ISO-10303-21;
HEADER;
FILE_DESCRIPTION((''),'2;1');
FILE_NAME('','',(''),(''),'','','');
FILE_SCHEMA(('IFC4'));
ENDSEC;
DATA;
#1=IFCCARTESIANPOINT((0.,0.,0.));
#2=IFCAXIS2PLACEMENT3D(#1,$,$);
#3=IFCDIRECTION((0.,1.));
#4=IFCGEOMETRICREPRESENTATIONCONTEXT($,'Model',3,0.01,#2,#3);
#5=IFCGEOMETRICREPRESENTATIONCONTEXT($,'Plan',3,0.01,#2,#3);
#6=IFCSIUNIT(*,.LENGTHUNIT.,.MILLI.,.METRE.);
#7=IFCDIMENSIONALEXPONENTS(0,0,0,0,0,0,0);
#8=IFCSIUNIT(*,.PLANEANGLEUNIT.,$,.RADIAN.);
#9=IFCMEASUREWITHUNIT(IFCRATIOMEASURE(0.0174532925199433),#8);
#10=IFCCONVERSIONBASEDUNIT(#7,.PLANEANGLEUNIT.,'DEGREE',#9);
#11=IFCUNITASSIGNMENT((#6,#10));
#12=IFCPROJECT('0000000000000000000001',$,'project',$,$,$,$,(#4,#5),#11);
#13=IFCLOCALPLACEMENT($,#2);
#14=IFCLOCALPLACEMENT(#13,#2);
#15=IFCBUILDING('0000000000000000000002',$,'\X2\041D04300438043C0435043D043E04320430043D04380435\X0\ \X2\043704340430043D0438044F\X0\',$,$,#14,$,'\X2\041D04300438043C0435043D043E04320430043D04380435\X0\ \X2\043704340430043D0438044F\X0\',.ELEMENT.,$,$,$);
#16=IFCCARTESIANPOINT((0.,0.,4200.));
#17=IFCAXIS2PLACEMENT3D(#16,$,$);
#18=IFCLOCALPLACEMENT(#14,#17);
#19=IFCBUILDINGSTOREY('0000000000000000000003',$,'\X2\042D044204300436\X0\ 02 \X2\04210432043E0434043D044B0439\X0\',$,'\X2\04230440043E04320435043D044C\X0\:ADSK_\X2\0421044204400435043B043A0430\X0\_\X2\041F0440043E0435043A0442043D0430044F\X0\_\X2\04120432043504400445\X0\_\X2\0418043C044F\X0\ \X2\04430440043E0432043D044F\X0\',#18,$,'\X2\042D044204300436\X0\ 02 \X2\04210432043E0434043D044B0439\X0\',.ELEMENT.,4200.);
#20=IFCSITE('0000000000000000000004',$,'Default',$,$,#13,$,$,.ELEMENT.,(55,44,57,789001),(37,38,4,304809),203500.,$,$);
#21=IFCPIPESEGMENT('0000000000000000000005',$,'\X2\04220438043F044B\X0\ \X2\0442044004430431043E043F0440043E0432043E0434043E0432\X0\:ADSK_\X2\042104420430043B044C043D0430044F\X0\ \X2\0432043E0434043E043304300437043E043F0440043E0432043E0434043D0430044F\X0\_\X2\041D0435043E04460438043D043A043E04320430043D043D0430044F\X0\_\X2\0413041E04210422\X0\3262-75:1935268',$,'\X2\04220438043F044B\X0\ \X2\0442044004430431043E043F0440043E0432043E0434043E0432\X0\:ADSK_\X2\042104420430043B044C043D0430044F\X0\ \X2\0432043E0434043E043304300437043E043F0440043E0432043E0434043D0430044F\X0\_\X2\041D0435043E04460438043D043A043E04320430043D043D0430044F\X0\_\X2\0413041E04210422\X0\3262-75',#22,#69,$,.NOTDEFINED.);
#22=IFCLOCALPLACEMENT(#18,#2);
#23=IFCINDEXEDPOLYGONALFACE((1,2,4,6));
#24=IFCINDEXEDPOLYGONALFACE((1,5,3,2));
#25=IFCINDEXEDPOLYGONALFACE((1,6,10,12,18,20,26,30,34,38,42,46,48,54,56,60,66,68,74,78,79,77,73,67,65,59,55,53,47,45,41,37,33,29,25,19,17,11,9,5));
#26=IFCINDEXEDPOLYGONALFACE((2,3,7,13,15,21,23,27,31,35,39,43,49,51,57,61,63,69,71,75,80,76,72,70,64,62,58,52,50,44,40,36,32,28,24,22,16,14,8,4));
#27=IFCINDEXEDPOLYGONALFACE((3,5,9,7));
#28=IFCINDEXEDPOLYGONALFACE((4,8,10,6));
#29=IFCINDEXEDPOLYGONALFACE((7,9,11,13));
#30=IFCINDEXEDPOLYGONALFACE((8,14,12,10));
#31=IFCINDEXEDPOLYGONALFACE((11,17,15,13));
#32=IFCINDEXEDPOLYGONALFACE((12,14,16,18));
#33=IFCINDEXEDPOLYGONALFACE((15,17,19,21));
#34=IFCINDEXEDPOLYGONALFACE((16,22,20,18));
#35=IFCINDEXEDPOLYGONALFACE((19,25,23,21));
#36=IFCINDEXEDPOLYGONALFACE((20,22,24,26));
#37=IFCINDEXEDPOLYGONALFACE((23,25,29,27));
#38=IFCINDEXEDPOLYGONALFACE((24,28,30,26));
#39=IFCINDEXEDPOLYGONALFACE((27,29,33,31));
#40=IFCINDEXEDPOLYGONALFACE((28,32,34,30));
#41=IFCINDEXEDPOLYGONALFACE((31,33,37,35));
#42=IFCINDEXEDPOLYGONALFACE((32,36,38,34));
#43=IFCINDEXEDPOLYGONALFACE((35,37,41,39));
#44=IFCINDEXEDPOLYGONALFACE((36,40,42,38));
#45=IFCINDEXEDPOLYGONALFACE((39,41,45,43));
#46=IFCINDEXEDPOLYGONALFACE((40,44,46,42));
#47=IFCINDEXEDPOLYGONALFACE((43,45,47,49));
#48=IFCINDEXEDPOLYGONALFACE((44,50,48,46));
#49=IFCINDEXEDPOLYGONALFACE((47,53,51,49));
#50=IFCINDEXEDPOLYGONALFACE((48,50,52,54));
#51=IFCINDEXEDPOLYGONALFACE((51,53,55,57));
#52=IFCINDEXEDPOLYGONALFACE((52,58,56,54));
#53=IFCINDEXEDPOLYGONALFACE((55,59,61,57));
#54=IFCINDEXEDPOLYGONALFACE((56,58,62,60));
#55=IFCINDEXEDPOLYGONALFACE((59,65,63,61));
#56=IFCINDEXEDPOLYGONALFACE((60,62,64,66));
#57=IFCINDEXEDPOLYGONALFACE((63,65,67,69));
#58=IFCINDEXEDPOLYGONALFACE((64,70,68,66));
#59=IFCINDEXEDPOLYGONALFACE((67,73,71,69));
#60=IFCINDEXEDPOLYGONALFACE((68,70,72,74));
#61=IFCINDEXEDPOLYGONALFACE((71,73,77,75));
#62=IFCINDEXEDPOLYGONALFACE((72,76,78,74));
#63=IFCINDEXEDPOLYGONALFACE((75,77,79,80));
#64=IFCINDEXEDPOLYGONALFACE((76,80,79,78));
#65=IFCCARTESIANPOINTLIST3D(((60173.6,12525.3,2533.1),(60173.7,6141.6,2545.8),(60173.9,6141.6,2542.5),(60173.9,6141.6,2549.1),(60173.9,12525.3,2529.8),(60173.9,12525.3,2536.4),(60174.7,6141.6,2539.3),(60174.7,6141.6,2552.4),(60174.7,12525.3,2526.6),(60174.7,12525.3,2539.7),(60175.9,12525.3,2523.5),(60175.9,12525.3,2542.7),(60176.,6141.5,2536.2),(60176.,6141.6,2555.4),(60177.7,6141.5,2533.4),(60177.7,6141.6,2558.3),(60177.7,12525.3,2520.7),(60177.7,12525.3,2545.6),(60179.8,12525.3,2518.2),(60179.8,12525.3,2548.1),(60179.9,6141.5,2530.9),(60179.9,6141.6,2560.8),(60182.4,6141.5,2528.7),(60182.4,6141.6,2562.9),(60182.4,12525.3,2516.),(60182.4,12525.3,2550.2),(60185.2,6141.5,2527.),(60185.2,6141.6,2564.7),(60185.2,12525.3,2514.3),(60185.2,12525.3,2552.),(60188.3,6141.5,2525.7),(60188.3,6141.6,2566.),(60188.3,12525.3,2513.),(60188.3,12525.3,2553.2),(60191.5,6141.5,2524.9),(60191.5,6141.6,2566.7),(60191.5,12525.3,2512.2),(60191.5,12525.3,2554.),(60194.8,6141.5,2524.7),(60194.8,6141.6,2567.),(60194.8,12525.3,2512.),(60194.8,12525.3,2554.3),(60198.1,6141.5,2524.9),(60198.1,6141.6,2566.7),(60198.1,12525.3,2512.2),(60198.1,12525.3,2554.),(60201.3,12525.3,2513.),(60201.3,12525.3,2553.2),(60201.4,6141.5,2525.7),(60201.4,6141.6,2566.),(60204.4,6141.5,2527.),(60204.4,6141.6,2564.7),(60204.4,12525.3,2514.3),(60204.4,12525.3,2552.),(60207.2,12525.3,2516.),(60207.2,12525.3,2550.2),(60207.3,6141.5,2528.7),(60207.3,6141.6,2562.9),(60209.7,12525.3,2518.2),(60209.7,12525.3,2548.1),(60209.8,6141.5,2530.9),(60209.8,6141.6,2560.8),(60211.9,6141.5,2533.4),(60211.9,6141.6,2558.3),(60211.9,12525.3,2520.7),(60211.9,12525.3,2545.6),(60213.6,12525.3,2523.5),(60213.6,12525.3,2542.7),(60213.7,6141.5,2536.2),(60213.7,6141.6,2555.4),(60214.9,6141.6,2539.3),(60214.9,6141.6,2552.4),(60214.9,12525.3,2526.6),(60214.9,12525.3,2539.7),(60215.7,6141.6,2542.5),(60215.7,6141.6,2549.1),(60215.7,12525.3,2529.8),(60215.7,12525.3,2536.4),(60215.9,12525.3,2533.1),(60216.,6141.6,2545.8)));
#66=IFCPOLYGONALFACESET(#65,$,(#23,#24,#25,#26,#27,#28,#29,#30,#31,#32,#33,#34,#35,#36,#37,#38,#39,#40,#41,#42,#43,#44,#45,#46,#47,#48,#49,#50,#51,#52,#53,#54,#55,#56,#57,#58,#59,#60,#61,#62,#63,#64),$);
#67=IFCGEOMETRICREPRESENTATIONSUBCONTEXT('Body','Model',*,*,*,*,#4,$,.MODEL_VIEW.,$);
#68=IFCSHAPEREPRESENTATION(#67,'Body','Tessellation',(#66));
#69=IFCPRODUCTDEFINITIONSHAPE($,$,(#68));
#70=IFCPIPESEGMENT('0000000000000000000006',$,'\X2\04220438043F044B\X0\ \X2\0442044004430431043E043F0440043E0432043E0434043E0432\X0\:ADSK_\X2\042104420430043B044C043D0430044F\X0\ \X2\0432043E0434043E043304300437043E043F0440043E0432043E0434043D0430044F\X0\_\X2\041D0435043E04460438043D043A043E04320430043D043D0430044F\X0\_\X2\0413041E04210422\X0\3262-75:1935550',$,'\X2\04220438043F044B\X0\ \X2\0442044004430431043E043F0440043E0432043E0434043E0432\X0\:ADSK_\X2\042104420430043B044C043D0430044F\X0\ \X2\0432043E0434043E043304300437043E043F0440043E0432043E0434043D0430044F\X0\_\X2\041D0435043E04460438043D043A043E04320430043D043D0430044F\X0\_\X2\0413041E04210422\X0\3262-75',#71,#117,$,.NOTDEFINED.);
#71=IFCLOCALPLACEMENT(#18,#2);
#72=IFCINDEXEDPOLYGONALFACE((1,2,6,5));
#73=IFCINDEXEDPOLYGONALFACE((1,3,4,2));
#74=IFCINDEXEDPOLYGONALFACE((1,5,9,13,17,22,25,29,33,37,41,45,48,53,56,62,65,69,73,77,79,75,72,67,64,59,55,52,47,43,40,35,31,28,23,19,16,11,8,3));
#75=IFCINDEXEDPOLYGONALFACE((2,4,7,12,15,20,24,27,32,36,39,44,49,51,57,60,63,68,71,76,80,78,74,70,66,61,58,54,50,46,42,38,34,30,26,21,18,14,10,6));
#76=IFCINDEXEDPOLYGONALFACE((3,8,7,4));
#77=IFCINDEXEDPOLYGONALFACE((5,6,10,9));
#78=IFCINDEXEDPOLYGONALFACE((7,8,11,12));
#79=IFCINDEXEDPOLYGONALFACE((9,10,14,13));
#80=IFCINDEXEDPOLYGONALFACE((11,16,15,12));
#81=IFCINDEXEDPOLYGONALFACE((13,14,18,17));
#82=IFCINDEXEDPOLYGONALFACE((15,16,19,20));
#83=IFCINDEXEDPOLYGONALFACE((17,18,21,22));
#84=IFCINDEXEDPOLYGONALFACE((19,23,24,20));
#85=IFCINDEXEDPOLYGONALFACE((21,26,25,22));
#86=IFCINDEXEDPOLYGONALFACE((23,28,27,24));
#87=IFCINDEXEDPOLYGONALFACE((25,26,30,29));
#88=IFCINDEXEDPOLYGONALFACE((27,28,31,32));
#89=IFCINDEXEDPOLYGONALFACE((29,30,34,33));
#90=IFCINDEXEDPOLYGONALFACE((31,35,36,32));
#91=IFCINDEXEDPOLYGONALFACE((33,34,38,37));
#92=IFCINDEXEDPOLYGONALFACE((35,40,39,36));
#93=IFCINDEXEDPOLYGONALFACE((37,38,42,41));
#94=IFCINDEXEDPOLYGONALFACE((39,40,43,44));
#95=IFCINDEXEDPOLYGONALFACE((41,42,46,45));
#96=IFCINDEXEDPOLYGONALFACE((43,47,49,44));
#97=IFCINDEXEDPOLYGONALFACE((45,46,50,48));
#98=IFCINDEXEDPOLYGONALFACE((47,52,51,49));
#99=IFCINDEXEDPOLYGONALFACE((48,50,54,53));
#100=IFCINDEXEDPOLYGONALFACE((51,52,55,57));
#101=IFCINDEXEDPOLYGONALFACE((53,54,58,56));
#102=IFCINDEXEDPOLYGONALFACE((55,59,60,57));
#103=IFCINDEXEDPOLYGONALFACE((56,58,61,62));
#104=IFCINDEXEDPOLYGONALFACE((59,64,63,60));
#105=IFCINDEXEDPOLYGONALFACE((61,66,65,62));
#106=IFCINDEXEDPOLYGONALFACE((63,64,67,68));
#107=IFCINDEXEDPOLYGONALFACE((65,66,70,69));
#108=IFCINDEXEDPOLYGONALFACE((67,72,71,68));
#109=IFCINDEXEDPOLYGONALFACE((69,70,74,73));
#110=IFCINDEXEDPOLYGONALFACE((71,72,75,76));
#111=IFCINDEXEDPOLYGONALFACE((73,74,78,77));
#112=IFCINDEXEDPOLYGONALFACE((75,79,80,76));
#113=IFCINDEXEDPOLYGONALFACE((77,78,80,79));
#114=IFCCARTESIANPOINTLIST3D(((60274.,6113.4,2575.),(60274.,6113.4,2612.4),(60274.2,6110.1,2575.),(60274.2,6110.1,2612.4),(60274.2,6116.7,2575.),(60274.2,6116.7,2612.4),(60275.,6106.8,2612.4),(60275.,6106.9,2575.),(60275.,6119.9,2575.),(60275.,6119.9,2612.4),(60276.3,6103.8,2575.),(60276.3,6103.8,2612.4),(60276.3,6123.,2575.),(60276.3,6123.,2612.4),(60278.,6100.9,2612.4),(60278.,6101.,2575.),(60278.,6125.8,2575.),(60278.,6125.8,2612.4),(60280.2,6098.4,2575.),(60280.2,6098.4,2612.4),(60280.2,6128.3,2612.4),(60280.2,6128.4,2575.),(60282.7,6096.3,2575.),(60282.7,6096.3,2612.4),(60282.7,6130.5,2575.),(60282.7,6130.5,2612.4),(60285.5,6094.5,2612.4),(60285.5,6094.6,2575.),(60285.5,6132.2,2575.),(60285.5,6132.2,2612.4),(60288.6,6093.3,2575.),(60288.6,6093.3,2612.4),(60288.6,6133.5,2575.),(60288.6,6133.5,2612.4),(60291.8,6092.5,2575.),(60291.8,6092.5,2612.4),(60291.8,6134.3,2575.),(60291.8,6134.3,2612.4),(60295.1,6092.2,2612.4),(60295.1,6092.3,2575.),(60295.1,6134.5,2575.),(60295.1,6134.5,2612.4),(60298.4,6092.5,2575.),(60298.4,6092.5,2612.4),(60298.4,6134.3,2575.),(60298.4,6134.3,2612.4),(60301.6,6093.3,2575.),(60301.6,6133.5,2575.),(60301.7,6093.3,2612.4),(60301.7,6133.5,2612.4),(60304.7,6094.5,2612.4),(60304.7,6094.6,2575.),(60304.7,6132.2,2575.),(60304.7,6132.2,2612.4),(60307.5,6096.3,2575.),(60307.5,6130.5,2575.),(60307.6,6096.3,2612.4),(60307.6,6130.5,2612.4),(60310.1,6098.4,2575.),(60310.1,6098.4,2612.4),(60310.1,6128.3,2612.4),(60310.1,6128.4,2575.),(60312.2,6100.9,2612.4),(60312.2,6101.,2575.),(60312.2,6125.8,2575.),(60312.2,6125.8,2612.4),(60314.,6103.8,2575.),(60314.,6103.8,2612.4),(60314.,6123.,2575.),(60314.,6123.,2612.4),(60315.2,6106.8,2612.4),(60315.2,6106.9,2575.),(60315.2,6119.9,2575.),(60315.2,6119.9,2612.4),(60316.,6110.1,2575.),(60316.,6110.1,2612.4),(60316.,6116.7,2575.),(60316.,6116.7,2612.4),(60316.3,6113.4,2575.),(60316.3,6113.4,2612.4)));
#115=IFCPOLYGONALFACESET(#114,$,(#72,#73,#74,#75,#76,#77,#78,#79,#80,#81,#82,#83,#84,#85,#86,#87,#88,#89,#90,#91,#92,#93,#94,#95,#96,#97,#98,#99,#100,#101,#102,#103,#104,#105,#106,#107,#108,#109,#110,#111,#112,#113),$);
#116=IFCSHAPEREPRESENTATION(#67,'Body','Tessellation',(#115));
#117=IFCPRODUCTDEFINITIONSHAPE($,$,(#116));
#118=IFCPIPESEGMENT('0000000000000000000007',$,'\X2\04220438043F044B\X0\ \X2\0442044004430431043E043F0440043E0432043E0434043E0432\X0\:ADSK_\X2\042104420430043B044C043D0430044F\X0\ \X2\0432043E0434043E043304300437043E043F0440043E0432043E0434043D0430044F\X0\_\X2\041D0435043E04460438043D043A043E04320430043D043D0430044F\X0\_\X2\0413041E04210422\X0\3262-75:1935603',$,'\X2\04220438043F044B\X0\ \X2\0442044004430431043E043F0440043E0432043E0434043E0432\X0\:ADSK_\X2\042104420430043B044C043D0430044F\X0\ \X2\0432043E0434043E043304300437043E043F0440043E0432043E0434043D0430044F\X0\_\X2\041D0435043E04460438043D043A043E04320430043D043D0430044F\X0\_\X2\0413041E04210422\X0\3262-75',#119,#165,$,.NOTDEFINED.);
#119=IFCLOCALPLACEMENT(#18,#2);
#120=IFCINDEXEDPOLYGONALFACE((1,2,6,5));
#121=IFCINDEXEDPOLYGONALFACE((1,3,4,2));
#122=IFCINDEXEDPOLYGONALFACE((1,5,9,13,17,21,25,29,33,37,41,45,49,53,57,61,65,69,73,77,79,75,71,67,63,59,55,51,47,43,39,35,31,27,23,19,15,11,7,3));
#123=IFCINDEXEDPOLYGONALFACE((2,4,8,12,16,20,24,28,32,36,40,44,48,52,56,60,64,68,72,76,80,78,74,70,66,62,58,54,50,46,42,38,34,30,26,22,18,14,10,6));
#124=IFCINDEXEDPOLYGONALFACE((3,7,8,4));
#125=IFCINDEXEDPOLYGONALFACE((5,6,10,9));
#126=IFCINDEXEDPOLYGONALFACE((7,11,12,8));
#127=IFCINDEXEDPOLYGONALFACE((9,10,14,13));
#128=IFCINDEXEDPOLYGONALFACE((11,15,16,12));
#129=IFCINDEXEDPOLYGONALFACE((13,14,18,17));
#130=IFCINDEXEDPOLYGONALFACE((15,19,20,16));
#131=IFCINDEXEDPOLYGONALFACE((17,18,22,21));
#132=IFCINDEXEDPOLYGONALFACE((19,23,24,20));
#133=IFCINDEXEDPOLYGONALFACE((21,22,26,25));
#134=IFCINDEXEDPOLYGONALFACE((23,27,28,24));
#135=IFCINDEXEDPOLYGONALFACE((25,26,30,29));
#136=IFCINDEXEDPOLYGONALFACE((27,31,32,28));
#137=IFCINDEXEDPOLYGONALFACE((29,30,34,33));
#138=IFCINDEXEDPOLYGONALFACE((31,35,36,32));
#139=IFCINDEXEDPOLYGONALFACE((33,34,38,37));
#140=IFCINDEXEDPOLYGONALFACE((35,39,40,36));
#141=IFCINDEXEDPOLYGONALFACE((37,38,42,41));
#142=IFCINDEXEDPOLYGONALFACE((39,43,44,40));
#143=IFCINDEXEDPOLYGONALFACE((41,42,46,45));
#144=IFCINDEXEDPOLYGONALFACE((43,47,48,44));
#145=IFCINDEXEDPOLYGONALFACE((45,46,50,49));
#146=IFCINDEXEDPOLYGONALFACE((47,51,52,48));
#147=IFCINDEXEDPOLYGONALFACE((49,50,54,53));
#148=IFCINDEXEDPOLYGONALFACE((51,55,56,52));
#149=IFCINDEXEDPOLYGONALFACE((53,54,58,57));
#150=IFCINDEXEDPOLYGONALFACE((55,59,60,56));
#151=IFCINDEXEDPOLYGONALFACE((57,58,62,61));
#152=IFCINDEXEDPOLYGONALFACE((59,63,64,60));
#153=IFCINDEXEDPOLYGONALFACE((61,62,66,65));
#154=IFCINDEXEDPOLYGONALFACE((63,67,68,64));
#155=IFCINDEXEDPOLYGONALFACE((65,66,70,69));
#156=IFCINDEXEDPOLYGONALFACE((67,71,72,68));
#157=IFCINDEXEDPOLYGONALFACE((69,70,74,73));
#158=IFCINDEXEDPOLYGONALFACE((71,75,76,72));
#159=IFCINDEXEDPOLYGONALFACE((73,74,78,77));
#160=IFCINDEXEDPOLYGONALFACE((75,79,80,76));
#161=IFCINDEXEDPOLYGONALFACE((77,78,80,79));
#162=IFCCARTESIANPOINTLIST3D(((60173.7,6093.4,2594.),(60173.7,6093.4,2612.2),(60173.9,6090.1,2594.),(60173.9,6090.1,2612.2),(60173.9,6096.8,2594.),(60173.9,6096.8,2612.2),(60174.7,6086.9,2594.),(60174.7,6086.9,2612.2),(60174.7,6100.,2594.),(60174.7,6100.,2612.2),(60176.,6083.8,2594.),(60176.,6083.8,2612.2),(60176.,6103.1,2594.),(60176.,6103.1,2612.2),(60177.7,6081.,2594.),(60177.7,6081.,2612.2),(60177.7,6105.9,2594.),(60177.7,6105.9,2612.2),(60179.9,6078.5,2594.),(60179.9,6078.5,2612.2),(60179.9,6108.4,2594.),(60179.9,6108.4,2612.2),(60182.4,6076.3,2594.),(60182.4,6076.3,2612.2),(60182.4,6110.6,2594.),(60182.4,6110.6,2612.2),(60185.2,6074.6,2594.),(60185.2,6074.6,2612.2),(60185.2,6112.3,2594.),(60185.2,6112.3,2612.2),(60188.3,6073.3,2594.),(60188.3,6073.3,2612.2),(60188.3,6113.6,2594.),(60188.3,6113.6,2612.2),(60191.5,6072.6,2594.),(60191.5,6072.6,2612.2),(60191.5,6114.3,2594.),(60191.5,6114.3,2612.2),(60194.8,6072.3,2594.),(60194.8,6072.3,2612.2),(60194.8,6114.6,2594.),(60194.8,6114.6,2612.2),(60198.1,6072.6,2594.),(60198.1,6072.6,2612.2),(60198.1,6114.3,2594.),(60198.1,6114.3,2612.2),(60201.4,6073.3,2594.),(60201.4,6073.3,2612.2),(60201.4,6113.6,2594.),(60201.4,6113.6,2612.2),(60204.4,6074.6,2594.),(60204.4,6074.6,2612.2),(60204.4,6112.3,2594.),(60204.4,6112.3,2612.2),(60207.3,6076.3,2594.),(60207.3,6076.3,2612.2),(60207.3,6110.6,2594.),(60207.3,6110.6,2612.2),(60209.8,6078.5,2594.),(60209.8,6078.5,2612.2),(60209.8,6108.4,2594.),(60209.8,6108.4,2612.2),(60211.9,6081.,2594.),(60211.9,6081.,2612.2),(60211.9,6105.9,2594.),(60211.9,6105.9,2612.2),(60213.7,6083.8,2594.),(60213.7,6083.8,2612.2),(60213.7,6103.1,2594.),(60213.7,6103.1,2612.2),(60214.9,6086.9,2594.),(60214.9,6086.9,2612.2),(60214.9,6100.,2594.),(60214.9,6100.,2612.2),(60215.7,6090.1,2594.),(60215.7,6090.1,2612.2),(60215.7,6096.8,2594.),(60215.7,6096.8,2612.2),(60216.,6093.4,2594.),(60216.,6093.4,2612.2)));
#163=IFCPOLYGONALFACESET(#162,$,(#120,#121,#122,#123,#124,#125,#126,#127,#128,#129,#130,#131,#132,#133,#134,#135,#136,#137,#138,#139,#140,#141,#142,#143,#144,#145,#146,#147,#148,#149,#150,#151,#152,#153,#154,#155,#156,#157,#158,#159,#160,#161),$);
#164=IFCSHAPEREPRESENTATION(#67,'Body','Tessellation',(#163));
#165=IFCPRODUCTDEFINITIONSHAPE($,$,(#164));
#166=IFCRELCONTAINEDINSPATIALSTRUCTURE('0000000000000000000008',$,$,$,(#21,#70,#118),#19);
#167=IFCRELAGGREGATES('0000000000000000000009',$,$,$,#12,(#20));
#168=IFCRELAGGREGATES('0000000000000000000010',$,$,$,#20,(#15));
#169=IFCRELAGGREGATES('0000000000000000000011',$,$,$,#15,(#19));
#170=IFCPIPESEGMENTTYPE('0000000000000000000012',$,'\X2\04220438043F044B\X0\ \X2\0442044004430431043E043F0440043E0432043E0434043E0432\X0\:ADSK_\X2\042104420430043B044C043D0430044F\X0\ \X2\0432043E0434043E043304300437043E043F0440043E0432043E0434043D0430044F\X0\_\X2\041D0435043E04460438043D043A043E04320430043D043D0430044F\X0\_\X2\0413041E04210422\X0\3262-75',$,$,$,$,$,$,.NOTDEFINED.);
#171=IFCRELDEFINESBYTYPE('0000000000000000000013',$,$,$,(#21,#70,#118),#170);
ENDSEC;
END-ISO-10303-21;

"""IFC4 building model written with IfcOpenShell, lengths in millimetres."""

from ifc_helpers import new_model, entity, si_unit, converted_unit, direction, frame, origin, place, context, subcontext, project, spatial, indexed_curve, outline, extrude, type_object, element, save


model = new_model("IFC4")

# Units and contexts
model_context = context("Model", 3, precision=0.01, world=origin(), true_north=direction((0.0, 1.0)))
plan_context = context("Plan", 3, precision=0.01, world=origin(), true_north=direction((0.0, 1.0)))
body_context = subcontext(model_context, "Body", "Model", "MODEL_VIEW")
ifc_project = project(units=[si_unit("LENGTHUNIT", "METRE", prefix="MILLI"), converted_unit("PLANEANGLEUNIT", "DEGREE", entity("IfcRatioMeasure", 0.0174532925199433), si_unit("PLANEANGLEUNIT", "RADIAN"), dimensions=[0, 0, 0, 0, 0, 0, 0])], contexts=[model_context, plan_context])

# Site, building, storey
site_placement = place(None, origin())
site = spatial("IfcSite", under=ifc_project, at=site_placement, Name="Default", CompositionType="ELEMENT", RefLatitude=(55, 44, 57, 789001), RefLongitude=(37, 38, 4, 304809), RefElevation=203500.0)
building_placement = place(site_placement, origin())
building = spatial("IfcBuilding", under=site, at=building_placement, Name="Наименование здания", LongName="Наименование здания", CompositionType="ELEMENT")
storey_placement = place(building_placement, frame((0.0, 0.0, 4200.0)))
storey = spatial("IfcBuildingStorey", under=building, at=storey_placement, Name="Этаж 02 Сводный", ObjectType="Уровень:ADSK_Стрелка_Проектная_Вверх_Имя уровня", LongName="Этаж 02 Сводный", CompositionType="ELEMENT", Elevation=4200.0)

# Pipe segments
placement = place(storey_placement, origin())
pipe_segment_type_1 = type_object("IfcPipeSegmentType", Name="Типы трубопроводов:ADSK_Стальная водогазопроводная_Неоцинкованная_ГОСТ3262-75", PredefinedType="NOTDEFINED")
element("IfcPipeSegment", 1, at=placement, inside=storey, type_object=pipe_segment_type_1, Name="Типы трубопроводов:ADSK_Стальная водогазопроводная_Неоцинкованная_ГОСТ3262-75:1935268", ObjectType="Типы трубопроводов:ADSK_Стальная водогазопроводная_Неоцинкованная_ГОСТ3262-75", PredefinedType="NOTDEFINED", context=body_context, shape_type="SweptSolid", body=[
    extrude(outline(indexed_curve([(21.1, 0.0), (20.9, 3.3), (20.1, 6.5), (18.8, 9.6), (17.1, 12.4), (15.0, 15.0), (12.4, 17.1), (9.6, 18.8), (6.5, 20.1), (3.3, 20.9), (0.0, 21.2), (-3.3, 20.9), (-6.5, 20.1), (-9.6, 18.8), (-12.4, 17.1), (-15.0, 15.0), (-17.1, 12.4), (-18.8, 9.6), (-20.1, 6.5), (-20.9, 3.3), (-21.1, 0.0), (-20.9, -3.3), (-20.1, -6.5), (-18.8, -9.6), (-17.1, -12.4), (-15.0, -15.0), (-12.4, -17.1), (-9.6, -18.8), (-6.5, -20.1), (-3.3, -20.9), (0.0, -21.2), (3.3, -20.9), (6.5, -20.1), (9.6, -18.8), (12.4, -17.1), (15.0, -15.0), (17.1, -12.4), (18.8, -9.6), (20.1, -6.5), (20.9, -3.3), (21.1, 0.0)], self_intersect=False)), frame((60194.8, 12525.3, 2533.1), z_axis=(0.000007, -0.999998, 0.001992), x_axis=(1.0, 0.000007, 0.0)), (0.0, 0.0, 1.0), 6383.7),
])
element("IfcPipeSegment", 2, at=placement, inside=storey, type_object=pipe_segment_type_1, Name="Типы трубопроводов:ADSK_Стальная водогазопроводная_Неоцинкованная_ГОСТ3262-75:1935550", ObjectType="Типы трубопроводов:ADSK_Стальная водогазопроводная_Неоцинкованная_ГОСТ3262-75", PredefinedType="NOTDEFINED", context=body_context, shape_type="SweptSolid", body=[
    extrude(outline(indexed_curve([(21.2, 0.0), (20.9, 3.3), (20.1, 6.5), (18.8, 9.6), (17.1, 12.4), (15.0, 15.0), (12.4, 17.1), (9.6, 18.8), (6.5, 20.1), (3.3, 20.9), (0.0, 21.1), (-3.3, 20.9), (-6.5, 20.1), (-9.6, 18.8), (-12.4, 17.1), (-15.0, 15.0), (-17.1, 12.4), (-18.8, 9.6), (-20.1, 6.5), (-20.9, 3.3), (-21.2, 0.0), (-20.9, -3.3), (-20.1, -6.5), (-18.8, -9.6), (-17.1, -12.4), (-15.0, -15.0), (-12.4, -17.1), (-9.6, -18.8), (-6.5, -20.1), (-3.3, -20.9), (0.0, -21.1), (3.3, -20.9), (6.5, -20.1), (9.6, -18.8), (12.4, -17.1), (15.0, -15.0), (17.1, -12.4), (18.8, -9.6), (20.1, -6.5), (20.9, -3.3), (21.2, 0.0)], self_intersect=False)), frame((60295.1, 6113.4, 2575.0), z_axis=(0.000636, -0.000614, 1.0), x_axis=(-1.0, 0.0, 0.000636)), (0.0, 0.0, 1.0), 37.4),
])
element("IfcPipeSegment", 3, at=placement, inside=storey, type_object=pipe_segment_type_1, Name="Типы трубопроводов:ADSK_Стальная водогазопроводная_Неоцинкованная_ГОСТ3262-75:1935603", ObjectType="Типы трубопроводов:ADSK_Стальная водогазопроводная_Неоцинкованная_ГОСТ3262-75", PredefinedType="NOTDEFINED", context=body_context, shape_type="SweptSolid", body=[
    extrude(outline(indexed_curve([(21.1, 0.0), (20.9, 3.3), (20.1, 6.5), (18.8, 9.6), (17.1, 12.4), (15.0, 15.0), (12.4, 17.1), (9.6, 18.8), (6.5, 20.1), (3.3, 20.9), (0.0, 21.1), (-3.3, 20.9), (-6.5, 20.1), (-9.6, 18.8), (-12.4, 17.1), (-15.0, 15.0), (-17.1, 12.4), (-18.8, 9.6), (-20.1, 6.5), (-20.9, 3.3), (-21.1, 0.0), (-20.9, -3.3), (-20.1, -6.5), (-18.8, -9.6), (-17.1, -12.4), (-15.0, -15.0), (-12.4, -17.1), (-9.6, -18.8), (-6.5, -20.1), (-3.3, -20.9), (0.0, -21.1), (3.3, -20.9), (6.5, -20.1), (9.6, -18.8), (12.4, -17.1), (15.0, -15.0), (17.1, -12.4), (18.8, -9.6), (20.1, -6.5), (20.9, -3.3), (21.1, 0.0)], self_intersect=False)), frame((60194.8, 6093.4, 2594.0)), (0.0, 0.0, 1.0), 18.2),
])

save(model, "model.ifc")
